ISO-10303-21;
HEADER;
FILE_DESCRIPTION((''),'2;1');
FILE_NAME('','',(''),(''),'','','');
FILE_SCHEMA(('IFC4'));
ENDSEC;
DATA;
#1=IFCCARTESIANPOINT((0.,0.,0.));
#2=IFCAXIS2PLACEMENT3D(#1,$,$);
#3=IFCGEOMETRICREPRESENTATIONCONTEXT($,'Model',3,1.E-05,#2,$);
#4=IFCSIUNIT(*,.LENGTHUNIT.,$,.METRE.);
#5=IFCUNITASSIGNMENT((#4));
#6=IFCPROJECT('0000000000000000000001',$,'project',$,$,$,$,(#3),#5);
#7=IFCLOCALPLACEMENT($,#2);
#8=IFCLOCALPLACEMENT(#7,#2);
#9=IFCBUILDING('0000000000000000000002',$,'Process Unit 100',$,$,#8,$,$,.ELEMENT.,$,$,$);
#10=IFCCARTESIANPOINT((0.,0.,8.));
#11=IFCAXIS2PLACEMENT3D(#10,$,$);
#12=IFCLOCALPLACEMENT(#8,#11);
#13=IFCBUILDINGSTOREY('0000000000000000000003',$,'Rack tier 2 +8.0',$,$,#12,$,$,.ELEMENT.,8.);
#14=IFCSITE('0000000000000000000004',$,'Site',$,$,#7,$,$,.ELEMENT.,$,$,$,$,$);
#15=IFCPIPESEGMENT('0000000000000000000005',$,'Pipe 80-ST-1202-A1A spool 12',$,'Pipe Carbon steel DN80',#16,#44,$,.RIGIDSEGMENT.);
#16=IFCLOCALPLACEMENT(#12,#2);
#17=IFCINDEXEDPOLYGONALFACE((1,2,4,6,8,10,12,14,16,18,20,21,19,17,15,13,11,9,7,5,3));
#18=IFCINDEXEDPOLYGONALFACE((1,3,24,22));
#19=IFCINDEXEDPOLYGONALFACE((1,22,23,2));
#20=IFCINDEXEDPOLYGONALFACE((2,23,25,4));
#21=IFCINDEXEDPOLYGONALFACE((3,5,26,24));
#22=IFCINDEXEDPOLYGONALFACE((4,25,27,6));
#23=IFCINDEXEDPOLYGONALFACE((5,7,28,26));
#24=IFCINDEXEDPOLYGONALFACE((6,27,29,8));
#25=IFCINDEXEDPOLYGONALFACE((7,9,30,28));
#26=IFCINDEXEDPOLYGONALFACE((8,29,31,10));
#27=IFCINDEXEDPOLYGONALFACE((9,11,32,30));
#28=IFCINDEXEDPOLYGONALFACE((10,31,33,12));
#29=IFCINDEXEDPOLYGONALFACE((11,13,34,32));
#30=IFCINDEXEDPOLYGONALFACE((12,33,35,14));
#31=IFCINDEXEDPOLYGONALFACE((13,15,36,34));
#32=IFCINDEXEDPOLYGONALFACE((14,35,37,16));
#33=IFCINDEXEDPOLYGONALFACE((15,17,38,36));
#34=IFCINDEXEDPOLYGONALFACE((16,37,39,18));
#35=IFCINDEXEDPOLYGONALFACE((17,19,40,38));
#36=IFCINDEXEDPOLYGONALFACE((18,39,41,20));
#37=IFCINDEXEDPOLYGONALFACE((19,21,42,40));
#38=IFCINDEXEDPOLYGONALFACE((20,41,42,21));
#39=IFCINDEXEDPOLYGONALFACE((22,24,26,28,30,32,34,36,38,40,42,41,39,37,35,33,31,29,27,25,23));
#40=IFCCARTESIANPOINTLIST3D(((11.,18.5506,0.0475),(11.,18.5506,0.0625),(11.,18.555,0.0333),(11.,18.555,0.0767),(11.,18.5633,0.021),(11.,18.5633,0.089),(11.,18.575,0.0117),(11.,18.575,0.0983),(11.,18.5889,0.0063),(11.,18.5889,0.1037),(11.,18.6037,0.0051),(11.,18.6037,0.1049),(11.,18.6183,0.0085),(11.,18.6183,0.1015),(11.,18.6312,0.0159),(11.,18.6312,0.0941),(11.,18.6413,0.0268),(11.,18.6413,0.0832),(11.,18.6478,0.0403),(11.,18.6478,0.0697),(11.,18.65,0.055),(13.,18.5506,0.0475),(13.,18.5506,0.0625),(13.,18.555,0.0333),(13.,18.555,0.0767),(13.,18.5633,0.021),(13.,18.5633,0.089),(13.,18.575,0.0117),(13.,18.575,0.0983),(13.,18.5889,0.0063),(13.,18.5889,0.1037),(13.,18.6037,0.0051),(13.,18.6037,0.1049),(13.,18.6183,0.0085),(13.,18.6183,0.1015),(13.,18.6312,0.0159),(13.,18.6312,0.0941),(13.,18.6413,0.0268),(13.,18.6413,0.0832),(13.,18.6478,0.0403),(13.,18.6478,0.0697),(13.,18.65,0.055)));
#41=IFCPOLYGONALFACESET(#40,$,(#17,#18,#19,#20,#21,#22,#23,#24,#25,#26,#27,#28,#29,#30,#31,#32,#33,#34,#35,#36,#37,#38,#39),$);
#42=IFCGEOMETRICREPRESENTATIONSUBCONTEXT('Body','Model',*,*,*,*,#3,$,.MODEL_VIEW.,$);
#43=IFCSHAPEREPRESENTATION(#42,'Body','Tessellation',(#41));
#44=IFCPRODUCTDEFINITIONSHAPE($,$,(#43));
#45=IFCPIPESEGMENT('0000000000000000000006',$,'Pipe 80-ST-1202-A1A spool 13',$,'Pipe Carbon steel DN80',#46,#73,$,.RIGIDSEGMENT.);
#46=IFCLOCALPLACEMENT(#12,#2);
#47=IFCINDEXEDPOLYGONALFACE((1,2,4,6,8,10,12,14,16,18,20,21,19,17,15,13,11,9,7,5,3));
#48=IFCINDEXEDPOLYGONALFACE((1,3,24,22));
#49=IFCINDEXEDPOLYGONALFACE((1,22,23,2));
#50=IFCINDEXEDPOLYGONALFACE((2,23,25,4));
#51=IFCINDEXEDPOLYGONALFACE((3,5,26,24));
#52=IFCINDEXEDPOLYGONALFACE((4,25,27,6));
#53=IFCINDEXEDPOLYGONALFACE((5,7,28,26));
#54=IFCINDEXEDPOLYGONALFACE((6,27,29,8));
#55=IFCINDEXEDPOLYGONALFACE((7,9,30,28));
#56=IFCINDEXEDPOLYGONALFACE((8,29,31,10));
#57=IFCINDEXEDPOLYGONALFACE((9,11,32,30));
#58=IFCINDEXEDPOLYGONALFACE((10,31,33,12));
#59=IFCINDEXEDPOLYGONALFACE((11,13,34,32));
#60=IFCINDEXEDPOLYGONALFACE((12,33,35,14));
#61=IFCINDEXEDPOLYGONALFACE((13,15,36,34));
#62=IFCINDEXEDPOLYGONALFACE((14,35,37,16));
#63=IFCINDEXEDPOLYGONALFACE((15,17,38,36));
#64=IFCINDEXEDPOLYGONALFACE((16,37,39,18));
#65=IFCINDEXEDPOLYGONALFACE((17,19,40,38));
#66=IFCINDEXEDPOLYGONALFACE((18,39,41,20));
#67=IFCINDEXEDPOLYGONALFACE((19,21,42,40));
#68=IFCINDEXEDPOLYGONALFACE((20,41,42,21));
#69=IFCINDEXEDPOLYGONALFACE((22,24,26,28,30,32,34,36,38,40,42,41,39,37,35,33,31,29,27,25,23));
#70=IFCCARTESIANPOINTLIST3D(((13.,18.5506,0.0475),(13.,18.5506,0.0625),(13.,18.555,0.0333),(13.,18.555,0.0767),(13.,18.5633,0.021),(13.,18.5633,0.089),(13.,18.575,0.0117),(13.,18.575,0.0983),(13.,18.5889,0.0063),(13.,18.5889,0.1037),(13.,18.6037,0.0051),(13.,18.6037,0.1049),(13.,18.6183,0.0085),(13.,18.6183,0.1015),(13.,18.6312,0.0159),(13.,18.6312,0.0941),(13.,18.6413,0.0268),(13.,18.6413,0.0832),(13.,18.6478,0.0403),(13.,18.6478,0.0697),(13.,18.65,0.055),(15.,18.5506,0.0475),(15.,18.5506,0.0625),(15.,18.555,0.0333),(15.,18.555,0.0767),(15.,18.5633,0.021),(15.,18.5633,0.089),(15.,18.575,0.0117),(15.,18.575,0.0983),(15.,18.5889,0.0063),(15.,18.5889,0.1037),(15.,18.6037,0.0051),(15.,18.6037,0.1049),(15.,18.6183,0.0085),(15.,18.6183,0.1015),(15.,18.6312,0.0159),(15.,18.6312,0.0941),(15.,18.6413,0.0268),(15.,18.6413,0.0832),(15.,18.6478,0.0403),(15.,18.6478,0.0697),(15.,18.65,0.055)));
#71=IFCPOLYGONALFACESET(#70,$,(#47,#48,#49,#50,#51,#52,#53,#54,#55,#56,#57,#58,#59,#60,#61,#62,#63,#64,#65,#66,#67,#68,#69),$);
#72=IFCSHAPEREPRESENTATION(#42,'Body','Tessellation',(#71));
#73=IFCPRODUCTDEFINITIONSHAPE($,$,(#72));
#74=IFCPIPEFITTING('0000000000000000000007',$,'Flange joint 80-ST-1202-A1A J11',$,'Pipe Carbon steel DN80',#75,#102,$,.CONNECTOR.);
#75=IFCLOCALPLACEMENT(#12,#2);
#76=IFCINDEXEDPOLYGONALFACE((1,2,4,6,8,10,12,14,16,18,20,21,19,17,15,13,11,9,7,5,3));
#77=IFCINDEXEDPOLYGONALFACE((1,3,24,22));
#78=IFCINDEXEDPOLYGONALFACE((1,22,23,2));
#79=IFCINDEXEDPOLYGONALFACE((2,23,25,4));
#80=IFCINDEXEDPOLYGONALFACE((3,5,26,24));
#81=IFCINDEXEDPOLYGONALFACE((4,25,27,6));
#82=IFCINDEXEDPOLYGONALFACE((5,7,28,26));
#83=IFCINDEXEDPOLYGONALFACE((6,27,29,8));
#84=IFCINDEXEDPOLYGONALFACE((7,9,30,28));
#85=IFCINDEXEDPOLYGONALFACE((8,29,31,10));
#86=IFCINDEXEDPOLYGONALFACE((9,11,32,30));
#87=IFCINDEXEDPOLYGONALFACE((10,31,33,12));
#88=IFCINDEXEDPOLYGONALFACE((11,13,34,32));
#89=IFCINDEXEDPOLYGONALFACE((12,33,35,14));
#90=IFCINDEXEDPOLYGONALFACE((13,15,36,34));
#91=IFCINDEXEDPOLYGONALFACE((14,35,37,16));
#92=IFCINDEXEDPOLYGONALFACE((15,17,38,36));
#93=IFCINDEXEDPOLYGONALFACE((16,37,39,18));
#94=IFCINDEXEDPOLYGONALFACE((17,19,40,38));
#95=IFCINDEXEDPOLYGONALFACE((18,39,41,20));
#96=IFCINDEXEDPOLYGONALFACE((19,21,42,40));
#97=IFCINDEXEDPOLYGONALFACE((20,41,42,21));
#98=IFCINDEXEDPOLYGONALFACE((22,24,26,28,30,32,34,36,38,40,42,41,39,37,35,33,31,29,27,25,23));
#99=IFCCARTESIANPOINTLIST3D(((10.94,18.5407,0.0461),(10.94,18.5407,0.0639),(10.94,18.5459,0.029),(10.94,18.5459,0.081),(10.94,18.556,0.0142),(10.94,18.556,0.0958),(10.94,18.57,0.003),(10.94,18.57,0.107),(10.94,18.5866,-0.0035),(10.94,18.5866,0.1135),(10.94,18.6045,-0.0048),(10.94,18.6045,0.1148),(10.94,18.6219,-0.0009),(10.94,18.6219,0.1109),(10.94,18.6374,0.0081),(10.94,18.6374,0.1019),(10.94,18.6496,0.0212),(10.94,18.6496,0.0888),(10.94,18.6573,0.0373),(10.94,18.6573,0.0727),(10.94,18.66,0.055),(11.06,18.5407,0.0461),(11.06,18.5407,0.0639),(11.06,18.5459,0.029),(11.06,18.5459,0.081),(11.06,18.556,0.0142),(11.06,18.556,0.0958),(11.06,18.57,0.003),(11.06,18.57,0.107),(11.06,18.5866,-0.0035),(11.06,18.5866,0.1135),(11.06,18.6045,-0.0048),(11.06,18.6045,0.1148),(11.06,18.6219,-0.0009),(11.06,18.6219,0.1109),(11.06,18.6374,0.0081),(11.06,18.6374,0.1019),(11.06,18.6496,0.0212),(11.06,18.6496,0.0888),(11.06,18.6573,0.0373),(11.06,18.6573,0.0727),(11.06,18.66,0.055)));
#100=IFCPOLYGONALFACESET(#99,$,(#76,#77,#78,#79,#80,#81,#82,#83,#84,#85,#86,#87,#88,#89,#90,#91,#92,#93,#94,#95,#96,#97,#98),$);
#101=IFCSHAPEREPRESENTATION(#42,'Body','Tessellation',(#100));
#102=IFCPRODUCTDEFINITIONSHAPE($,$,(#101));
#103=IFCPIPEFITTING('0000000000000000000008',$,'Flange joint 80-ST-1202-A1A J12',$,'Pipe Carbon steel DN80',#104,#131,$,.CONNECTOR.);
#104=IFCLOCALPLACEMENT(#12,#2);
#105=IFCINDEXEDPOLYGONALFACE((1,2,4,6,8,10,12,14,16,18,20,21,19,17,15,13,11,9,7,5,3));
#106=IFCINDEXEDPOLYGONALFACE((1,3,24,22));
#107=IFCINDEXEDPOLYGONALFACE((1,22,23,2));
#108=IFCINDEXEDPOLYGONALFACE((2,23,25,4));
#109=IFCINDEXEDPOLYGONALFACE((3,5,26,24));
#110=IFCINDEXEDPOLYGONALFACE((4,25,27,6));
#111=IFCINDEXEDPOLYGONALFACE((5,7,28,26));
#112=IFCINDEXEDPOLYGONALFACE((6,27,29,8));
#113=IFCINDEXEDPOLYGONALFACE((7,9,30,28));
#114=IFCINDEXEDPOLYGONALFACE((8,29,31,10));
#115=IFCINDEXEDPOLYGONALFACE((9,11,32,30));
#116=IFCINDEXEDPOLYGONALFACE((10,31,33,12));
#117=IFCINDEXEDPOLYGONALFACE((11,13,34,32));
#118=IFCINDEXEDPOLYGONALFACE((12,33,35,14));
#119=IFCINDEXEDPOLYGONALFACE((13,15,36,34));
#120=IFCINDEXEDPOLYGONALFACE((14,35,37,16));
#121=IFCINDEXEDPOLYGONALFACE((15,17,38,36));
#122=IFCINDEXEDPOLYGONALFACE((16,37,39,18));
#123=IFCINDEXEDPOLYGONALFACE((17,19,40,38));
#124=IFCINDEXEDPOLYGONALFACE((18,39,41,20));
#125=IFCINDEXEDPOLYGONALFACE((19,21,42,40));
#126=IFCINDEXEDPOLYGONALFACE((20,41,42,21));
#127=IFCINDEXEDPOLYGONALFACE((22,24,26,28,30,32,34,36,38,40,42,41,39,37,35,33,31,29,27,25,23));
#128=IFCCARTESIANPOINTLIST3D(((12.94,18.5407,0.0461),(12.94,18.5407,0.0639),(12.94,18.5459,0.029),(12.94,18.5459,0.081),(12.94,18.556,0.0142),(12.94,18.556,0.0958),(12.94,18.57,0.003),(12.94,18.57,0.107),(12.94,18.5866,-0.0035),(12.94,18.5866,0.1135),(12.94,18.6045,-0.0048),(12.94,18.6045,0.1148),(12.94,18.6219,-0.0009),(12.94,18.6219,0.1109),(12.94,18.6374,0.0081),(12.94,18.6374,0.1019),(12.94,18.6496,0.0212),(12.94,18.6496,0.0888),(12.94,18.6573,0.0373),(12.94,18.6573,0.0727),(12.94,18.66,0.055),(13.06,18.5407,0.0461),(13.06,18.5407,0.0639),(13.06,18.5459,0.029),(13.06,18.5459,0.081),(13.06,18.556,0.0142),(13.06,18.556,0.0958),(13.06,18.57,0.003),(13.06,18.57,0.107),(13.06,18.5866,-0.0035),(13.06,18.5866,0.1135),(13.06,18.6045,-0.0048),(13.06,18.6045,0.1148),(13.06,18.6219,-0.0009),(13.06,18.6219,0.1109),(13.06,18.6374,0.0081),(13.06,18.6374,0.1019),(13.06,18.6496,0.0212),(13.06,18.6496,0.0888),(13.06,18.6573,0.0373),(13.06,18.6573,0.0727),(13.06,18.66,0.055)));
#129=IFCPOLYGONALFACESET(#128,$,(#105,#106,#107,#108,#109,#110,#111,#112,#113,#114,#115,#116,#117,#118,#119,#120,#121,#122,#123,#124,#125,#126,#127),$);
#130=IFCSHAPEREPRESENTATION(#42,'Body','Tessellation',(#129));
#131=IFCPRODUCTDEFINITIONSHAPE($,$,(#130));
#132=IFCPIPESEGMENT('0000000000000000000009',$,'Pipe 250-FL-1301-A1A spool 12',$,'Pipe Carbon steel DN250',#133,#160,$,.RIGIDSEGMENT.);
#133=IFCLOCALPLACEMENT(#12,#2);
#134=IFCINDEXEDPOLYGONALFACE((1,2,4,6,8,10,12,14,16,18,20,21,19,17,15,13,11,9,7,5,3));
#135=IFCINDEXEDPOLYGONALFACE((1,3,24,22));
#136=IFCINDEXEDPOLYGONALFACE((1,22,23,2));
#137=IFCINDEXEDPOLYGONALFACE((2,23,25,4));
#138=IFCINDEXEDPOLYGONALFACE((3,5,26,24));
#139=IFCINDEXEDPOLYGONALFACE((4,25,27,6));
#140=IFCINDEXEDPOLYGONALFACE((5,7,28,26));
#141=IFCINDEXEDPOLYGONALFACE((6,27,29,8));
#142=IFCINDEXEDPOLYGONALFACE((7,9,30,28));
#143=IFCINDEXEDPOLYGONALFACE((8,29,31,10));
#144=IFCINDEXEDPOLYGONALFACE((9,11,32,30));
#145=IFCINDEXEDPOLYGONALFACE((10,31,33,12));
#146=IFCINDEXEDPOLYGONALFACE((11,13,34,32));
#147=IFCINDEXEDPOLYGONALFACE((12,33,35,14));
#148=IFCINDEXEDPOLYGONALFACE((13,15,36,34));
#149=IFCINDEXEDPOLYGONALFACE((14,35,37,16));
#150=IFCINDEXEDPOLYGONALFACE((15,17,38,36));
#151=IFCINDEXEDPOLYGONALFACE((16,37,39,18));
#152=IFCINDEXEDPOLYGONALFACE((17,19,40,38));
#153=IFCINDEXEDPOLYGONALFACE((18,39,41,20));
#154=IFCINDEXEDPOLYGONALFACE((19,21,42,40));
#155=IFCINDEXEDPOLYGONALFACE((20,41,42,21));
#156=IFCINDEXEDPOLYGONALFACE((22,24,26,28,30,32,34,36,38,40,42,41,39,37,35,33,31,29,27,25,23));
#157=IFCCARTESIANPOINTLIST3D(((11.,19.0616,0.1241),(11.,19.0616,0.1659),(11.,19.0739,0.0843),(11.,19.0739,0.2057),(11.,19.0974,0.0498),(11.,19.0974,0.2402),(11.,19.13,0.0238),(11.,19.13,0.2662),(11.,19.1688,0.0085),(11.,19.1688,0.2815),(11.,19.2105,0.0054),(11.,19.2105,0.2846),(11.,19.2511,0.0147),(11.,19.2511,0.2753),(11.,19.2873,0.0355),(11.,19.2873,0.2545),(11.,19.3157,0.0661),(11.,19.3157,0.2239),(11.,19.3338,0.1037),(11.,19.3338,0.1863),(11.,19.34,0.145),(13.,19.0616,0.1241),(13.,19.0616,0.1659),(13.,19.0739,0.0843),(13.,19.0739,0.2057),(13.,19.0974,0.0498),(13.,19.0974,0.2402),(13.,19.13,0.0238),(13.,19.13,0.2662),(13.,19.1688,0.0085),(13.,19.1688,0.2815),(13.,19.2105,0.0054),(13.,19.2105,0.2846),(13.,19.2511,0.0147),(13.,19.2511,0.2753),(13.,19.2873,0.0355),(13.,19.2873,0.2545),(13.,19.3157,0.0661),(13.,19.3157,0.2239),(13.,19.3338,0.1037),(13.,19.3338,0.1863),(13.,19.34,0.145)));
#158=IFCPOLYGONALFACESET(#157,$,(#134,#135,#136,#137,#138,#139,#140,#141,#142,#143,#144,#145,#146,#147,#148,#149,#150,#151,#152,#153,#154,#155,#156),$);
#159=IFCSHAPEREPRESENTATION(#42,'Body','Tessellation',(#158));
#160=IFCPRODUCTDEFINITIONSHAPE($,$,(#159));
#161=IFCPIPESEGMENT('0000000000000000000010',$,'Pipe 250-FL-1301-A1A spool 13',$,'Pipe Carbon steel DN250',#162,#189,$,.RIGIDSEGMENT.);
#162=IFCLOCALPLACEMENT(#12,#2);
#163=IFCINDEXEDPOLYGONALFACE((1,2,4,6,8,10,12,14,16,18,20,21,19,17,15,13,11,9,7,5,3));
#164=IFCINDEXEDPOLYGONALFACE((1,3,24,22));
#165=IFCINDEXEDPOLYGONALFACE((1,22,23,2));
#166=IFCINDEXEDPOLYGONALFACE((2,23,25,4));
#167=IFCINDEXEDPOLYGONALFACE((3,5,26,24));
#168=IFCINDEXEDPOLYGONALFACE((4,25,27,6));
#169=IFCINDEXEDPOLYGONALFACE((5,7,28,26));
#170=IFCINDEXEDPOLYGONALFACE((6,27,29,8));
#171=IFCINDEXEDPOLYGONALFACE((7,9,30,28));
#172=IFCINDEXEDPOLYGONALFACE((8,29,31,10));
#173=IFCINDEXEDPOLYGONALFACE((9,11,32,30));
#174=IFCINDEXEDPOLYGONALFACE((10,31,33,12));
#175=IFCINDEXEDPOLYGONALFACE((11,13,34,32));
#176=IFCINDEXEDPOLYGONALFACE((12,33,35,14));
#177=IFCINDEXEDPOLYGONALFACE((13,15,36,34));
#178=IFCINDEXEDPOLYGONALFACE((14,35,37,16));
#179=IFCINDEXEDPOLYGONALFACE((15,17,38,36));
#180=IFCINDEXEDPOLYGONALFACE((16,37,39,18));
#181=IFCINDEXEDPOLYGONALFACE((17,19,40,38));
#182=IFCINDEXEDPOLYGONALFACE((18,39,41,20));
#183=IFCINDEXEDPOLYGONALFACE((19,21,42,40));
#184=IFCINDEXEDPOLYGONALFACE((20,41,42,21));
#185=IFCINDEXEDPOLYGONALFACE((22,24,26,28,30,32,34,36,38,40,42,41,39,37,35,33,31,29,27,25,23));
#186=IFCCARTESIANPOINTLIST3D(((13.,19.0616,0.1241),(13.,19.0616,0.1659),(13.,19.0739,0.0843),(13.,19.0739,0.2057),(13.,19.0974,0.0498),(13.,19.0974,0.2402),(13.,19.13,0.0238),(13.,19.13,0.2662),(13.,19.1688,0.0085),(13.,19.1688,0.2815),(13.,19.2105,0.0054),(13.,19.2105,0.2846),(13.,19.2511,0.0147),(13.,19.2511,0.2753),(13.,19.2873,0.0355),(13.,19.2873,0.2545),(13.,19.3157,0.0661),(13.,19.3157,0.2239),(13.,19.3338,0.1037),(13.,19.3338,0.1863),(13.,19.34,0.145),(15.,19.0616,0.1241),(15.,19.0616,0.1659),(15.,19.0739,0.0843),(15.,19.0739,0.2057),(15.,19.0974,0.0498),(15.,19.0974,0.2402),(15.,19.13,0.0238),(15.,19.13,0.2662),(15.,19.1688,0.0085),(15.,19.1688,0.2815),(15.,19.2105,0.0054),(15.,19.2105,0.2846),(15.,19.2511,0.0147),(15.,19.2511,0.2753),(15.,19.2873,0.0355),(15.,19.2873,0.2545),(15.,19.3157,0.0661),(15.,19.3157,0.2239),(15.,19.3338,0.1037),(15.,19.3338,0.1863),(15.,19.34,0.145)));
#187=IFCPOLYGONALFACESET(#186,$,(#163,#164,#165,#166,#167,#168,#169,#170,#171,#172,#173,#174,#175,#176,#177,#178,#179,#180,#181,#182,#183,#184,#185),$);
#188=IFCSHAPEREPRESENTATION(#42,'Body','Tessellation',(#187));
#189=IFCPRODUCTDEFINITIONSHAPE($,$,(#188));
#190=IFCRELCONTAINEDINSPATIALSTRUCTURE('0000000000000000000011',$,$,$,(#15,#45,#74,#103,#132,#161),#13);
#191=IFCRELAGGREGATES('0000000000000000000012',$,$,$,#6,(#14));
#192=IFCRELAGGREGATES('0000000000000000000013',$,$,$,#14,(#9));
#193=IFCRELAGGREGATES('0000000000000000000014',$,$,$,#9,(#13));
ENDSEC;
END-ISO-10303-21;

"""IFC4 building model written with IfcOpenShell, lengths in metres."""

from ifc_helpers import new_model, si_unit, frame, origin, place, context, subcontext, project, spatial, circle, extrude, element, save


model = new_model("IFC4")

# Units and contexts
model_context = context("Model", 3, precision=1e-05, world=origin())
body_context = subcontext(model_context, "Body", "Model", "MODEL_VIEW")
ifc_project = project(units=[si_unit("LENGTHUNIT", "METRE")], contexts=[model_context])

# Site, building, storey
site_placement = place(None, origin())
site = spatial("IfcSite", under=ifc_project, at=site_placement, Name="Site", CompositionType="ELEMENT")
building_placement = place(site_placement, origin())
building = spatial("IfcBuilding", under=site, at=building_placement, Name="Process Unit 100", CompositionType="ELEMENT")
storey_placement = place(building_placement, frame((0.0, 0.0, 8.0)))
storey = spatial("IfcBuildingStorey", under=building, at=storey_placement, Name="Rack tier 2 +8.0", CompositionType="ELEMENT", Elevation=8.0)

# Pipe segments
for number, where, z_axis, x_axis, name in (
    (1, (11.0, 18.6, 0.055), (1.0, 0.0, 0.0), (0.0, 1.0, 0.0), "Pipe 80-ST-1202-A1A spool 12"),
    (2, (13.0, 18.6, 0.055), (1.0, 0.0, 0.0), (0.0, 1.0, 0.0), "Pipe 80-ST-1202-A1A spool 13"),
):
    element("IfcPipeSegment", number, at=place(storey_placement, frame(where, z_axis=z_axis, x_axis=x_axis)), inside=storey, Name=name, ObjectType="Pipe Carbon steel DN80", PredefinedType="RIGIDSEGMENT", context=body_context, shape_type="SweptSolid", body=[
        extrude(circle(Radius=0.05), origin(), (0.0, 0.0, 1.0), 2.0),
    ])

# Pipe fittings
for number, where, z_axis, x_axis, name in (
    (3, (10.94, 18.6, 0.055), (1.0, 0.0, 0.0), (0.0, 1.0, 0.0), "Flange joint 80-ST-1202-A1A J11"),
    (4, (12.94, 18.6, 0.055), (1.0, 0.0, 0.0), (0.0, 1.0, 0.0), "Flange joint 80-ST-1202-A1A J12"),
):
    element("IfcPipeFitting", number, at=place(storey_placement, frame(where, z_axis=z_axis, x_axis=x_axis)), inside=storey, Name=name, ObjectType="Pipe Carbon steel DN80", PredefinedType="CONNECTOR", context=body_context, shape_type="SweptSolid", body=[
        extrude(circle(Radius=0.06), origin(), (0.0, 0.0, 1.0), 0.12),
    ])

# Pipe segments
for number, where, z_axis, x_axis, name in (
    (5, (11.0, 19.2, 0.145), (1.0, 0.0, 0.0), (0.0, 1.0, 0.0), "Pipe 250-FL-1301-A1A spool 12"),
    (6, (13.0, 19.2, 0.145), (1.0, 0.0, 0.0), (0.0, 1.0, 0.0), "Pipe 250-FL-1301-A1A spool 13"),
):
    element("IfcPipeSegment", number, at=place(storey_placement, frame(where, z_axis=z_axis, x_axis=x_axis)), inside=storey, Name=name, ObjectType="Pipe Carbon steel DN250", PredefinedType="RIGIDSEGMENT", context=body_context, shape_type="SweptSolid", body=[
        extrude(circle(Radius=0.14), origin(), (0.0, 0.0, 1.0), 2.0),
    ])

save(model, "model.ifc")
